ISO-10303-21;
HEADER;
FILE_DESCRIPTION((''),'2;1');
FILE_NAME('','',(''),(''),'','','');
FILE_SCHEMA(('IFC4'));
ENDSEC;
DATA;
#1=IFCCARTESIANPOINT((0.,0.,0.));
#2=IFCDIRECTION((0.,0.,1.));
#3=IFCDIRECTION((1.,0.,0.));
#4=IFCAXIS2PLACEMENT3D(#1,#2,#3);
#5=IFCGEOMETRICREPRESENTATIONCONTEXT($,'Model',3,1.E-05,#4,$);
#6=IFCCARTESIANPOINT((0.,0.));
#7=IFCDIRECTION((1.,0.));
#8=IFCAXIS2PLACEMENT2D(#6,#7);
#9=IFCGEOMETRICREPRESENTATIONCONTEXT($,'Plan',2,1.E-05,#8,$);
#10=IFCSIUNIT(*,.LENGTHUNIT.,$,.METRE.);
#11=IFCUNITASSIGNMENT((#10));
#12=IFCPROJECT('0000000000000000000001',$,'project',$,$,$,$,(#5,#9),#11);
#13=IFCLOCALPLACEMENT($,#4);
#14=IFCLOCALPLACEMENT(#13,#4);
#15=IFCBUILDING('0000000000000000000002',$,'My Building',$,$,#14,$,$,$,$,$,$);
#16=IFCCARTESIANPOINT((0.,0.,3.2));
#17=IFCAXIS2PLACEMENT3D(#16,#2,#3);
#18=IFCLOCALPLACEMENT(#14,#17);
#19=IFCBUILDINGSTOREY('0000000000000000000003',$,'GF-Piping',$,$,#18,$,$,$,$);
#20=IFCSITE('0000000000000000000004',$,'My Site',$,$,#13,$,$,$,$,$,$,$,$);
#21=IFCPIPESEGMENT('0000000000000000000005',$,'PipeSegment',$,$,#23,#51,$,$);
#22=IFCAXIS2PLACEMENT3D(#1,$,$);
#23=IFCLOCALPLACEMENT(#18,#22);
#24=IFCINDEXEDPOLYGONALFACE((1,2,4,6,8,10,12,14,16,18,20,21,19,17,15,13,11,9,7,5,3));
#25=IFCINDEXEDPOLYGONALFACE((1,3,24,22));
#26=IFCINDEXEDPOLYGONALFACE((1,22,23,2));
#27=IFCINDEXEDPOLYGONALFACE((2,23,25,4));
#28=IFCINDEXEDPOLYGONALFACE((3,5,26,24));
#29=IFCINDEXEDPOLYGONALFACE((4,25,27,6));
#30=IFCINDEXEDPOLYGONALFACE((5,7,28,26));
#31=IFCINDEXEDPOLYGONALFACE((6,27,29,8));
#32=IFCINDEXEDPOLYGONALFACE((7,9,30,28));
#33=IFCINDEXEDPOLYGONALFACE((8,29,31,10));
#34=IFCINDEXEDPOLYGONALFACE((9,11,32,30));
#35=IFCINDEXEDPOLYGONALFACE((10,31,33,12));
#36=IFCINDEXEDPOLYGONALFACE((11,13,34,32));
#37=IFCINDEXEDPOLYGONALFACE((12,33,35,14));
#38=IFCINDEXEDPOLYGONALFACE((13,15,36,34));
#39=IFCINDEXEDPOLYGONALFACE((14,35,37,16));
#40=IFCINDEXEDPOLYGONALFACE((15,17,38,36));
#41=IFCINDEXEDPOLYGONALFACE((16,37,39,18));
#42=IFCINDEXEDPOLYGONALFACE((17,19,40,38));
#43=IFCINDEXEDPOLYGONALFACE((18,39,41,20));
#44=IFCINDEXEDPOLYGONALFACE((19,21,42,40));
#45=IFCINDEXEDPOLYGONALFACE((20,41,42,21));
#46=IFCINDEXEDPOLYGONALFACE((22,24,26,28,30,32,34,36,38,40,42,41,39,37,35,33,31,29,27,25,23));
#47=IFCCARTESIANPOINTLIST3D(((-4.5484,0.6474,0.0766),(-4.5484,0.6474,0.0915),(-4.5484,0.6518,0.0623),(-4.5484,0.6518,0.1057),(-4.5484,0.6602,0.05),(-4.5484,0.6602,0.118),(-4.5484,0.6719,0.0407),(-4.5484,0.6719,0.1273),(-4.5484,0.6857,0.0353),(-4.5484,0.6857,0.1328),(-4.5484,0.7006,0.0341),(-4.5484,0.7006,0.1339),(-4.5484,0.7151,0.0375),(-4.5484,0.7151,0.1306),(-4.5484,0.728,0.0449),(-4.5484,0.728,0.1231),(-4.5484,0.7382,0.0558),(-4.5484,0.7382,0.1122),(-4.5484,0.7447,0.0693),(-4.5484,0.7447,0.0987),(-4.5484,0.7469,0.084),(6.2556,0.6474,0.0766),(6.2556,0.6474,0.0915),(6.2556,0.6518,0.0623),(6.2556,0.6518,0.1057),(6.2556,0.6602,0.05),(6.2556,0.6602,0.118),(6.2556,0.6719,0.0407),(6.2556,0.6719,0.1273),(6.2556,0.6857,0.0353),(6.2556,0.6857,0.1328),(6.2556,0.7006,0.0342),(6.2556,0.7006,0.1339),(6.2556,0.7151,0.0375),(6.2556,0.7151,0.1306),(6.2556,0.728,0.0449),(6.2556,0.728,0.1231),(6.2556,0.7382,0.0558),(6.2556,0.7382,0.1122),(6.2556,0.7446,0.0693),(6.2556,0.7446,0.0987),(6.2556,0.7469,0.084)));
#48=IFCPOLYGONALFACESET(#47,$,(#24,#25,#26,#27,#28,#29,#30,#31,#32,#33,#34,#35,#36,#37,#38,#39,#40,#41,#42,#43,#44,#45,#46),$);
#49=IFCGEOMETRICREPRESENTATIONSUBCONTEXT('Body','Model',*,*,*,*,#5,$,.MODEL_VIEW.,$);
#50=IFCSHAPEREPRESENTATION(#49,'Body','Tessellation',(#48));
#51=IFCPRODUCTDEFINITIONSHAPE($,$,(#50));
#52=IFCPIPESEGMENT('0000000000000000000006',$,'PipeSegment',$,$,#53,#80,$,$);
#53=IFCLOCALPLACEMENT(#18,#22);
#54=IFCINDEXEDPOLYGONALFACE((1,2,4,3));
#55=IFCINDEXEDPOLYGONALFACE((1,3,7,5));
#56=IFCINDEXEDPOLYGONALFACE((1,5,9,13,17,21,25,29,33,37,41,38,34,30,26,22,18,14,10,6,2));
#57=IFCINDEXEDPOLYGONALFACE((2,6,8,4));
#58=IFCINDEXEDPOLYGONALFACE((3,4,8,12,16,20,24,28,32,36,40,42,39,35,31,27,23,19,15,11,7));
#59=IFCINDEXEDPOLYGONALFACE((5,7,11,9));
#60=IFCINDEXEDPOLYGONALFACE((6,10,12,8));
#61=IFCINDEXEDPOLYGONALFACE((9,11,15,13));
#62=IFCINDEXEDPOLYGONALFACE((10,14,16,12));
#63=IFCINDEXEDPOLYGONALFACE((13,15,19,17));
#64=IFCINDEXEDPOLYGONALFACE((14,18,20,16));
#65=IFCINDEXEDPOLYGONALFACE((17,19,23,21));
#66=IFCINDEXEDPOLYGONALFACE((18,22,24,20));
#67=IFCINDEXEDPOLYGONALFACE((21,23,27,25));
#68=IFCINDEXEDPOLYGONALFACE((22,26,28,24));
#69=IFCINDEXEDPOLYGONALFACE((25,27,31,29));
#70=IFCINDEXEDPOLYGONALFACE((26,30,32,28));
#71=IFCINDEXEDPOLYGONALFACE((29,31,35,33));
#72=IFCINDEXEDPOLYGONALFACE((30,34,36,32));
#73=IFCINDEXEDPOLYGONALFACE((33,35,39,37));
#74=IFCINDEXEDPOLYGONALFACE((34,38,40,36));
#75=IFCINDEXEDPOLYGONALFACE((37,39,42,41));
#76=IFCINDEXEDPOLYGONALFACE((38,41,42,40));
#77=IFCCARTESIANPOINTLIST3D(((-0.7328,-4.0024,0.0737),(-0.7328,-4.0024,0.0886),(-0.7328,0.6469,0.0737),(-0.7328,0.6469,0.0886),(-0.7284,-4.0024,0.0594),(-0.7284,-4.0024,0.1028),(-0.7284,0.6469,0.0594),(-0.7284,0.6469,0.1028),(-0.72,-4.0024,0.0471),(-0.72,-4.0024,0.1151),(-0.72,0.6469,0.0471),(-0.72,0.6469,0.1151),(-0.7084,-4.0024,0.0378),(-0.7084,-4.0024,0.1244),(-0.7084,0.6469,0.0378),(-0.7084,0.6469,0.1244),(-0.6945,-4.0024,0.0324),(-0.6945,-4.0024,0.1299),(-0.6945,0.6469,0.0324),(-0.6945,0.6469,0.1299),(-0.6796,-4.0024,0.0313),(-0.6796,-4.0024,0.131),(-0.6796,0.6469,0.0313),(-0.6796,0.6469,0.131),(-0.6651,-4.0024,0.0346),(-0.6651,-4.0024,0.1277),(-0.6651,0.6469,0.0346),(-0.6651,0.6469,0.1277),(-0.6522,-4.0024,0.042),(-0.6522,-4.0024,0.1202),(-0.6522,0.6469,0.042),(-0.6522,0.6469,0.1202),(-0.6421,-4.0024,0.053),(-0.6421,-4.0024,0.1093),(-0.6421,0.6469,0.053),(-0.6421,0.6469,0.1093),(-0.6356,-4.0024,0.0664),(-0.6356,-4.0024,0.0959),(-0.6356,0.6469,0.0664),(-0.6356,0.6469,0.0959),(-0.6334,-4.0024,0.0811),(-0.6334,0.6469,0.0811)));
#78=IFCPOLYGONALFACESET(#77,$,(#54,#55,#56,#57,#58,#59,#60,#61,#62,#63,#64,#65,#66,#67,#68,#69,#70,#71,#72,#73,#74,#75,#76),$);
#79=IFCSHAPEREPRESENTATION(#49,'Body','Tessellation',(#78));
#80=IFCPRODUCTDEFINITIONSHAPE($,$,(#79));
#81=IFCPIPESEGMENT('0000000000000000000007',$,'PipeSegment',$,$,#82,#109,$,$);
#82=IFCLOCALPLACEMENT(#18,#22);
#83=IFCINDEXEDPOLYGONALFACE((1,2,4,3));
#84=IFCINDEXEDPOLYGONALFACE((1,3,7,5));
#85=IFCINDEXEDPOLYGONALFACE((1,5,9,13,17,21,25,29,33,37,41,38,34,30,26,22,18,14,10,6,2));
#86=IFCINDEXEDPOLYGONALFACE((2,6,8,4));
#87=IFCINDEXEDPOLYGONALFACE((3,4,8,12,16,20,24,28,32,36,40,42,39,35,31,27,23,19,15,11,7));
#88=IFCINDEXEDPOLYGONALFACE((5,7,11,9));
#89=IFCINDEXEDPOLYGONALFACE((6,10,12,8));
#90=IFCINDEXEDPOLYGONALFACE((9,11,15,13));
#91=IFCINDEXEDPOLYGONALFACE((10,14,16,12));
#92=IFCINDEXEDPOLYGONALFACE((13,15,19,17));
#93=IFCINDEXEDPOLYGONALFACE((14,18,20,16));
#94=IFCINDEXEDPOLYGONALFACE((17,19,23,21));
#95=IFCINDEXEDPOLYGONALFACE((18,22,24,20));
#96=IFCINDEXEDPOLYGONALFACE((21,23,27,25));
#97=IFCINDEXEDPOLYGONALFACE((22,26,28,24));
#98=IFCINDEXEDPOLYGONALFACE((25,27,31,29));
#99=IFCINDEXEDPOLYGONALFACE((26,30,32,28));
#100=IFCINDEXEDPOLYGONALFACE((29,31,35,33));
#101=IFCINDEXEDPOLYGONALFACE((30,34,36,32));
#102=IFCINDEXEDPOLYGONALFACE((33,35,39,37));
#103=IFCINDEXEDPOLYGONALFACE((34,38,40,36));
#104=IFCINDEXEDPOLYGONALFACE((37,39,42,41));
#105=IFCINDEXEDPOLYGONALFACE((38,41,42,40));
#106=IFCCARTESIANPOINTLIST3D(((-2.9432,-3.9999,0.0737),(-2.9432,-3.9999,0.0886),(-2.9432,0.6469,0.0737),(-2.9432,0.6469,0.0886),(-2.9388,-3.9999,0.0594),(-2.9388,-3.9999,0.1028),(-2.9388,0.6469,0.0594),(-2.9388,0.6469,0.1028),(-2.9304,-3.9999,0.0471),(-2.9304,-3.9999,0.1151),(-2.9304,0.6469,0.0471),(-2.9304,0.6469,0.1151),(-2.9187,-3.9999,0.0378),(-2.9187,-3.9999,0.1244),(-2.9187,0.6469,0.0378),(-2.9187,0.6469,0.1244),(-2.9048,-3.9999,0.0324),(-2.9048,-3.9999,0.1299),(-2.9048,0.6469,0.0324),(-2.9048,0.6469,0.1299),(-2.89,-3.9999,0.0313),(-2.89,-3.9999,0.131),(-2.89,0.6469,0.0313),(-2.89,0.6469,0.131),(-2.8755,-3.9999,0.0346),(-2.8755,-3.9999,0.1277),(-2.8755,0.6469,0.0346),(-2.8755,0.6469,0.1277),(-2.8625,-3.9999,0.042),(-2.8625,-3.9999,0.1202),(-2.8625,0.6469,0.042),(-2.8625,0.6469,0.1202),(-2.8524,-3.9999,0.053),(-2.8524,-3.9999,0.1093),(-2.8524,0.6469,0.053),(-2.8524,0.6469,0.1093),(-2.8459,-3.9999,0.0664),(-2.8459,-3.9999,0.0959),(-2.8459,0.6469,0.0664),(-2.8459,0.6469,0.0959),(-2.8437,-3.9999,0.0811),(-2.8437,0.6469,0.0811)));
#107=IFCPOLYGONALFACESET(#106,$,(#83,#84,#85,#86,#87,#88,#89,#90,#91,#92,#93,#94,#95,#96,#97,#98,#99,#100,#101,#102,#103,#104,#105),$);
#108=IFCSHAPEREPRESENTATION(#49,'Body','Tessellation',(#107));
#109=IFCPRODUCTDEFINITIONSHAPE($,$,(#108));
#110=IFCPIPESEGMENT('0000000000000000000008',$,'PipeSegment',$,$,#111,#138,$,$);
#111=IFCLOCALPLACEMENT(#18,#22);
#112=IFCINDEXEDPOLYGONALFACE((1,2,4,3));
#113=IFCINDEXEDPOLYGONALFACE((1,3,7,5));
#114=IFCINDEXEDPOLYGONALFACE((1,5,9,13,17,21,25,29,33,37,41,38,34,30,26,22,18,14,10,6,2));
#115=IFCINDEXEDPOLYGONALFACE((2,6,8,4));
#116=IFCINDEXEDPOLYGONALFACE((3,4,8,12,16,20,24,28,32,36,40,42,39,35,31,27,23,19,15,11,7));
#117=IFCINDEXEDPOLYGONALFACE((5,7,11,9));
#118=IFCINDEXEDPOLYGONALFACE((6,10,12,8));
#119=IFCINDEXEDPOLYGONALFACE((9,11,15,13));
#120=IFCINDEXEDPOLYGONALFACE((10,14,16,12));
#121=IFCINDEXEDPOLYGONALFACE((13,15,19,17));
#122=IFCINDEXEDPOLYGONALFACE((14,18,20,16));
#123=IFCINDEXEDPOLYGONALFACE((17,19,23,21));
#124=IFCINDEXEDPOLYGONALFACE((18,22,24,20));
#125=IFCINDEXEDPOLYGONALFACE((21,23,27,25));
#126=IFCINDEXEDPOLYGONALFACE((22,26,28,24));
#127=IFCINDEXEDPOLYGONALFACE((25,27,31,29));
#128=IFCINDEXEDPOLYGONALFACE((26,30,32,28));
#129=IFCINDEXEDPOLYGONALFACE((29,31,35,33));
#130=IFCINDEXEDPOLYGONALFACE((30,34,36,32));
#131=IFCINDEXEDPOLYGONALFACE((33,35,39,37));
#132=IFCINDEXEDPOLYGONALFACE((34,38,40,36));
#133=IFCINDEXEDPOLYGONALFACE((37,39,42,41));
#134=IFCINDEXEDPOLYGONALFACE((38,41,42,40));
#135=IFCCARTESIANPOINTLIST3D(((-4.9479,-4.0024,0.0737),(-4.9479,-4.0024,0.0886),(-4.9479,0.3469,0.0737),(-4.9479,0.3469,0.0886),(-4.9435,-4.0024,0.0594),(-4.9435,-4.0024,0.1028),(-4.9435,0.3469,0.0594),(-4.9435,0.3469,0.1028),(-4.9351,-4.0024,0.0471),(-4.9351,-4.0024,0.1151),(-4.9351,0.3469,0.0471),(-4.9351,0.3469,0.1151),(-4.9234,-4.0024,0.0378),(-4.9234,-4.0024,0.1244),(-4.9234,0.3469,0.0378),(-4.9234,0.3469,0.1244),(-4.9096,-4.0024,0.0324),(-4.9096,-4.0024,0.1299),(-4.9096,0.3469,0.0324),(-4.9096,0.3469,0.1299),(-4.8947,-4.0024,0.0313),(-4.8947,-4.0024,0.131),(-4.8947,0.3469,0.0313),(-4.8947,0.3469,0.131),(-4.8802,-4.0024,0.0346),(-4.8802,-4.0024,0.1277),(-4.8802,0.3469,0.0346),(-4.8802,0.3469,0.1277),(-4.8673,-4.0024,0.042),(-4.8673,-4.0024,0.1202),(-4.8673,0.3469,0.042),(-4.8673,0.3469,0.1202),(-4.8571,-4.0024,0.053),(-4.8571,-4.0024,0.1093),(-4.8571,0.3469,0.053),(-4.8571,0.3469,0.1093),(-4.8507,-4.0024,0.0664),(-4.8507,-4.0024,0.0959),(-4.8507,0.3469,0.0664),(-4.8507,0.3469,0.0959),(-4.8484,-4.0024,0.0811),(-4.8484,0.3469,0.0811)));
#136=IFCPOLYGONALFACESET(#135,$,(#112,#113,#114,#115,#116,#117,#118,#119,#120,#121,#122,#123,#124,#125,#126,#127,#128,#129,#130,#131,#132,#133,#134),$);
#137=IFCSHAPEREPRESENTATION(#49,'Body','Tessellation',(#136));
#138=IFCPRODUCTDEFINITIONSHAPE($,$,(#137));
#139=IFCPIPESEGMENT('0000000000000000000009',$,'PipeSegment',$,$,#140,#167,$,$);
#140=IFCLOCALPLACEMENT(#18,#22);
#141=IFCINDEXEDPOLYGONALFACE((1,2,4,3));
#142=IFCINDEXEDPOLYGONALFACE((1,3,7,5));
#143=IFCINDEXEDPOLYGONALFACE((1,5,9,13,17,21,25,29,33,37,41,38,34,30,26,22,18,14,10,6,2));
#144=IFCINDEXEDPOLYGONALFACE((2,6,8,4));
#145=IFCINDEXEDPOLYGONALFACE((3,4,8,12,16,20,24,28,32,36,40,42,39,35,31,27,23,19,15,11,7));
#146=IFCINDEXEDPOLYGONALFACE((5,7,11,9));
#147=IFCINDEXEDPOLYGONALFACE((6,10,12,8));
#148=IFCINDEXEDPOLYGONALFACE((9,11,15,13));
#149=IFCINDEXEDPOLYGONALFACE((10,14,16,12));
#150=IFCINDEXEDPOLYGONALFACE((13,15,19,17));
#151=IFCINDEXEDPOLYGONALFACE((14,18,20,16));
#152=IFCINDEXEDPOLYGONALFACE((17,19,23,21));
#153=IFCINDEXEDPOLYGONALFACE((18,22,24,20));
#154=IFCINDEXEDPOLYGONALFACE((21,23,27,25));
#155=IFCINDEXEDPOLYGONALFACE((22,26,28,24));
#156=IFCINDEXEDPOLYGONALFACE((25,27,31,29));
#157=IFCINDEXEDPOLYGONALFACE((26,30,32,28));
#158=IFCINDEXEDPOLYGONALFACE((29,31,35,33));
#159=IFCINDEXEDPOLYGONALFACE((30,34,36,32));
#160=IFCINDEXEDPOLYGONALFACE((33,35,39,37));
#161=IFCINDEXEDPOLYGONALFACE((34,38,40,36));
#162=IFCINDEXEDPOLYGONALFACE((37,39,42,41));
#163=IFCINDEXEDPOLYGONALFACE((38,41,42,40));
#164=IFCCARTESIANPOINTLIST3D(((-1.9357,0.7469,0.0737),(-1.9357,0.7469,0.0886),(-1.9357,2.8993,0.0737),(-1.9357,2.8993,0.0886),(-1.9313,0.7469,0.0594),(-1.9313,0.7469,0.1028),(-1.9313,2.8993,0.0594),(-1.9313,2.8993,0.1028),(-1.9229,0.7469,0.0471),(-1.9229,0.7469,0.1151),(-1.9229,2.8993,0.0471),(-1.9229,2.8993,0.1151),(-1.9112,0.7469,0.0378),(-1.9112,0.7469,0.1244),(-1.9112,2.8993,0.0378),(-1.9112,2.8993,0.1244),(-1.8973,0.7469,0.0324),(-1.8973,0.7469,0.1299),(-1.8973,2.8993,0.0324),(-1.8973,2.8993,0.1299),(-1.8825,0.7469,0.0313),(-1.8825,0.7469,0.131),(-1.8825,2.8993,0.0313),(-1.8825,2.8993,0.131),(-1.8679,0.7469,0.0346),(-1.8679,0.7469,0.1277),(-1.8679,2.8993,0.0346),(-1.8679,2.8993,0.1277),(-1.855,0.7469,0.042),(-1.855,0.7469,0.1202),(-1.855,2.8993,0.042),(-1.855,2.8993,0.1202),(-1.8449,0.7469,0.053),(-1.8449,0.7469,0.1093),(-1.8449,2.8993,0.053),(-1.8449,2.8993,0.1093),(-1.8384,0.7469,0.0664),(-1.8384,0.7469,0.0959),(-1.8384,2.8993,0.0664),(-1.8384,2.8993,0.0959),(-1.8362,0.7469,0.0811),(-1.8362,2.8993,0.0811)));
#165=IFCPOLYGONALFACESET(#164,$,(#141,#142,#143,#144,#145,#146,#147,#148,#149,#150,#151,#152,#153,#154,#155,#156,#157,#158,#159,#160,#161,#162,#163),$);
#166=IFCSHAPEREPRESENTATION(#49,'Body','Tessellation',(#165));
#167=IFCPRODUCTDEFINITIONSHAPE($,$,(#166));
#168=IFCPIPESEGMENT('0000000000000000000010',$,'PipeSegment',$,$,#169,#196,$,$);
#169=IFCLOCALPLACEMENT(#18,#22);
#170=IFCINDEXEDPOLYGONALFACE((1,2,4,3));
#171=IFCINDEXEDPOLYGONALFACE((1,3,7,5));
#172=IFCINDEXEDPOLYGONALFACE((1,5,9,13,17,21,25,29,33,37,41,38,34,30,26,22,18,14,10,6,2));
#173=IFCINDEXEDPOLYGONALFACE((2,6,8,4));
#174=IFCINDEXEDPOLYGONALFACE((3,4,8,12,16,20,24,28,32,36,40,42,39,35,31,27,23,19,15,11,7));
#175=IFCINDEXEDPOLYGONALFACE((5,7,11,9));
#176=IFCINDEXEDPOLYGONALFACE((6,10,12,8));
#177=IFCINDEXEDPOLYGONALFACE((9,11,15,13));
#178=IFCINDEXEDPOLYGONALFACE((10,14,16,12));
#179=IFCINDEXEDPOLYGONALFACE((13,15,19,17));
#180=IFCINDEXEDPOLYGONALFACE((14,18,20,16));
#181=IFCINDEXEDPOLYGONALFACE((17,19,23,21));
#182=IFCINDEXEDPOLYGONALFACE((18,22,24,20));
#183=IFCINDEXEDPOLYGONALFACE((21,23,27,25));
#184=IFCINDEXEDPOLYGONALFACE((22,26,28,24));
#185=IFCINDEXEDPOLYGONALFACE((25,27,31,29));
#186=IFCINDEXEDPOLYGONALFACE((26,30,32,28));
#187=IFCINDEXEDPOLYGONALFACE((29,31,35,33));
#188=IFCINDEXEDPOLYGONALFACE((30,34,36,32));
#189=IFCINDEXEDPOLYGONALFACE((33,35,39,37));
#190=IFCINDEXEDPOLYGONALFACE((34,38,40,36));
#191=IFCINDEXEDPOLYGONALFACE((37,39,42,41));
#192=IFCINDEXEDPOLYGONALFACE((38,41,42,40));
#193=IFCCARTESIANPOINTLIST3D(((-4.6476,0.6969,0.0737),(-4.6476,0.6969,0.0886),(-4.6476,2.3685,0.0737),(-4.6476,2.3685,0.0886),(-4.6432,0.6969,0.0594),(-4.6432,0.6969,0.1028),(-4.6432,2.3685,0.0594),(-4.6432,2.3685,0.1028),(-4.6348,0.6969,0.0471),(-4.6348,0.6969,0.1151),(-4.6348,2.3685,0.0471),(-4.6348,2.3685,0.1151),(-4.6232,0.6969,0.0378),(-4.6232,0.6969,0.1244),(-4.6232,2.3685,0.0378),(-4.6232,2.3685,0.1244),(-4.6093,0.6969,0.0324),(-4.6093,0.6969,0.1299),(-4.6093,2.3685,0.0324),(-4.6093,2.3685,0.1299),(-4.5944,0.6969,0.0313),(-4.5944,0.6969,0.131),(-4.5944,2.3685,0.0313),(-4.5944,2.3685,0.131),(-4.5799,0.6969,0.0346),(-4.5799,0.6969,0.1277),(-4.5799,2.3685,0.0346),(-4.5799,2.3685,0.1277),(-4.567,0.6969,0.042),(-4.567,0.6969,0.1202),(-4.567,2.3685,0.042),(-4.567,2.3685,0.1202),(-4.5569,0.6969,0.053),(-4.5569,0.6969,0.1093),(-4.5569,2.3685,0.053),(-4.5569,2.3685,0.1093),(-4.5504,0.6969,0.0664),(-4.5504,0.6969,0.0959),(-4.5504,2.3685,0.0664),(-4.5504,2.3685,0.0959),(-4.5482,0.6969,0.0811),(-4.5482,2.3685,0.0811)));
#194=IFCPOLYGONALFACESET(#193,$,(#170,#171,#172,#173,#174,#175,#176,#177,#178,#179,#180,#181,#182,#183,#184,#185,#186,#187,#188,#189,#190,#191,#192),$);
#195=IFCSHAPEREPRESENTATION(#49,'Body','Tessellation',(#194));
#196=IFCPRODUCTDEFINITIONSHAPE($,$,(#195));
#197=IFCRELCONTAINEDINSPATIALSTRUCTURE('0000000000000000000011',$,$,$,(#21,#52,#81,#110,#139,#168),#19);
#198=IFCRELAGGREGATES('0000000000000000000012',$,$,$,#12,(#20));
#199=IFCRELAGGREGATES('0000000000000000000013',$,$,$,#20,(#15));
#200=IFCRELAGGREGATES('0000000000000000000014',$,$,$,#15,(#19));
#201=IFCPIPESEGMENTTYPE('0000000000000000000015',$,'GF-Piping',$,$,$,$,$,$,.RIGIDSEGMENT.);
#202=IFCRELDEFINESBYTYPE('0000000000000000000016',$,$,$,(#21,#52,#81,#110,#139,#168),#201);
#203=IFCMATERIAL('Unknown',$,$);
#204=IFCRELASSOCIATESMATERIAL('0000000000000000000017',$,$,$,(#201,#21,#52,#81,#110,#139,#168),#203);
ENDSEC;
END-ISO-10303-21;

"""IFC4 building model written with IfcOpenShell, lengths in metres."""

from ifc_helpers import new_model, si_unit, frame, origin_with_axes, origin_2d_with_axis, place, context, subcontext, project, spatial, circle, extrude, material, material_profile, profile_set, profile_usage, type_object, element, save


model = new_model("IFC4")

# Units and contexts
model_context = context("Model", 3, precision=1e-05, world=origin_with_axes())
plan_context = context("Plan", 2, precision=1e-05, world=origin_2d_with_axis())
body_context = subcontext(model_context, "Body", "Model", "MODEL_VIEW")
ifc_project = project(units=[si_unit("LENGTHUNIT", "METRE")], contexts=[model_context, plan_context])

# Site, building, storey
site_placement = place(None, origin_with_axes())
site = spatial("IfcSite", under=ifc_project, at=site_placement, Name="My Site")
building_placement = place(site_placement, origin_with_axes())
building = spatial("IfcBuilding", under=site, at=building_placement, Name="My Building")
storey_placement = place(building_placement, frame((0.0, 0.0, 3.2), z_axis=(0.0, 0.0, 1.0), x_axis=(1.0, 0.0, 0.0)))
storey = spatial("IfcBuildingStorey", under=building, at=storey_placement, Name="GF-Piping")

# Pipe segments
ifc_material = material(Name="Unknown")
ifc_material_profile = material_profile(ifc_material, circle(Radius=0.05))
ifc_profile_set = profile_set([ifc_material_profile])
ifc_profile_usage_1 = profile_usage(ifc_profile_set, cardinal=5)
pipe_segment_type = type_object("IfcPipeSegmentType", Name="GF-Piping", PredefinedType="RIGIDSEGMENT", material=ifc_profile_set)
pipe_segment_1_placement = place(storey_placement, frame((-4.5484, 0.6969, 0.084), z_axis=(1.0, 0.0, 0.0), x_axis=(0.0, 1.0, 0.0)))
element("IfcPipeSegment", 1, at=pipe_segment_1_placement, inside=storey, type_object=pipe_segment_type, material=ifc_profile_usage_1, Name="PipeSegment", context=body_context, shape_type="SweptSolid", body=[
    extrude(circle(Radius=0.05), origin_with_axes(), (0.0, 0.0, 1.0), 10.8041),
])
ifc_profile_usage_2 = profile_usage(ifc_profile_set, cardinal=5)
pipe_segment_2_placement = place(storey_placement, frame((-0.6834, 0.6469, 0.0811), z_axis=(0.0, -1.0, 0.0), x_axis=(1.0, 0.0, 0.0)))
element("IfcPipeSegment", 2, at=pipe_segment_2_placement, inside=storey, type_object=pipe_segment_type, material=ifc_profile_usage_2, Name="PipeSegment", context=body_context, shape_type="SweptSolid", body=[
    extrude(circle(Radius=0.05), origin_with_axes(), (0.0, 0.0, 1.0), 4.6492),
])
ifc_profile_usage_3 = profile_usage(ifc_profile_set, cardinal=5)
pipe_segment_3_placement = place(storey_placement, frame((-2.8937, 0.6469, 0.0811), z_axis=(0.0, -1.0, 0.0), x_axis=(1.0, 0.0, 0.0)))
element("IfcPipeSegment", 3, at=pipe_segment_3_placement, inside=storey, type_object=pipe_segment_type, material=ifc_profile_usage_3, Name="PipeSegment", context=body_context, shape_type="SweptSolid", body=[
    extrude(circle(Radius=0.05), origin_with_axes(), (0.0, 0.0, 1.0), 4.6467),
])
ifc_profile_usage_4 = profile_usage(ifc_profile_set, cardinal=5)
pipe_segment_4_placement = place(storey_placement, frame((-4.8984, 0.3469, 0.0811), z_axis=(0.0, -1.0, 0.0), x_axis=(1.0, 0.0, 0.0)))
element("IfcPipeSegment", 4, at=pipe_segment_4_placement, inside=storey, type_object=pipe_segment_type, material=ifc_profile_usage_4, Name="PipeSegment", context=body_context, shape_type="SweptSolid", body=[
    extrude(circle(Radius=0.05), origin_with_axes(), (0.0, 0.0, 1.0), 4.3492),
])
ifc_profile_usage_5 = profile_usage(ifc_profile_set, cardinal=5)
pipe_segment_5_placement = place(storey_placement, frame((-1.8862, 2.8993, 0.0811), z_axis=(0.0, -1.0, 0.0), x_axis=(1.0, 0.0, 0.0)))
element("IfcPipeSegment", 5, at=pipe_segment_5_placement, inside=storey, type_object=pipe_segment_type, material=ifc_profile_usage_5, Name="PipeSegment", context=body_context, shape_type="SweptSolid", body=[
    extrude(circle(Radius=0.05), origin_with_axes(), (0.0, 0.0, 1.0), 2.1524),
])
ifc_profile_usage_6 = profile_usage(ifc_profile_set, cardinal=5)
pipe_segment_6_placement = place(storey_placement, frame((-4.5982, 2.3685, 0.0811), z_axis=(0.0, -1.0, 0.0), x_axis=(1.0, 0.0, 0.0)))
element("IfcPipeSegment", 6, at=pipe_segment_6_placement, inside=storey, type_object=pipe_segment_type, material=ifc_profile_usage_6, Name="PipeSegment", context=body_context, shape_type="SweptSolid", body=[
    extrude(circle(Radius=0.05), origin_with_axes(), (0.0, 0.0, 1.0), 1.6717),
])

save(model, "model.ifc")
